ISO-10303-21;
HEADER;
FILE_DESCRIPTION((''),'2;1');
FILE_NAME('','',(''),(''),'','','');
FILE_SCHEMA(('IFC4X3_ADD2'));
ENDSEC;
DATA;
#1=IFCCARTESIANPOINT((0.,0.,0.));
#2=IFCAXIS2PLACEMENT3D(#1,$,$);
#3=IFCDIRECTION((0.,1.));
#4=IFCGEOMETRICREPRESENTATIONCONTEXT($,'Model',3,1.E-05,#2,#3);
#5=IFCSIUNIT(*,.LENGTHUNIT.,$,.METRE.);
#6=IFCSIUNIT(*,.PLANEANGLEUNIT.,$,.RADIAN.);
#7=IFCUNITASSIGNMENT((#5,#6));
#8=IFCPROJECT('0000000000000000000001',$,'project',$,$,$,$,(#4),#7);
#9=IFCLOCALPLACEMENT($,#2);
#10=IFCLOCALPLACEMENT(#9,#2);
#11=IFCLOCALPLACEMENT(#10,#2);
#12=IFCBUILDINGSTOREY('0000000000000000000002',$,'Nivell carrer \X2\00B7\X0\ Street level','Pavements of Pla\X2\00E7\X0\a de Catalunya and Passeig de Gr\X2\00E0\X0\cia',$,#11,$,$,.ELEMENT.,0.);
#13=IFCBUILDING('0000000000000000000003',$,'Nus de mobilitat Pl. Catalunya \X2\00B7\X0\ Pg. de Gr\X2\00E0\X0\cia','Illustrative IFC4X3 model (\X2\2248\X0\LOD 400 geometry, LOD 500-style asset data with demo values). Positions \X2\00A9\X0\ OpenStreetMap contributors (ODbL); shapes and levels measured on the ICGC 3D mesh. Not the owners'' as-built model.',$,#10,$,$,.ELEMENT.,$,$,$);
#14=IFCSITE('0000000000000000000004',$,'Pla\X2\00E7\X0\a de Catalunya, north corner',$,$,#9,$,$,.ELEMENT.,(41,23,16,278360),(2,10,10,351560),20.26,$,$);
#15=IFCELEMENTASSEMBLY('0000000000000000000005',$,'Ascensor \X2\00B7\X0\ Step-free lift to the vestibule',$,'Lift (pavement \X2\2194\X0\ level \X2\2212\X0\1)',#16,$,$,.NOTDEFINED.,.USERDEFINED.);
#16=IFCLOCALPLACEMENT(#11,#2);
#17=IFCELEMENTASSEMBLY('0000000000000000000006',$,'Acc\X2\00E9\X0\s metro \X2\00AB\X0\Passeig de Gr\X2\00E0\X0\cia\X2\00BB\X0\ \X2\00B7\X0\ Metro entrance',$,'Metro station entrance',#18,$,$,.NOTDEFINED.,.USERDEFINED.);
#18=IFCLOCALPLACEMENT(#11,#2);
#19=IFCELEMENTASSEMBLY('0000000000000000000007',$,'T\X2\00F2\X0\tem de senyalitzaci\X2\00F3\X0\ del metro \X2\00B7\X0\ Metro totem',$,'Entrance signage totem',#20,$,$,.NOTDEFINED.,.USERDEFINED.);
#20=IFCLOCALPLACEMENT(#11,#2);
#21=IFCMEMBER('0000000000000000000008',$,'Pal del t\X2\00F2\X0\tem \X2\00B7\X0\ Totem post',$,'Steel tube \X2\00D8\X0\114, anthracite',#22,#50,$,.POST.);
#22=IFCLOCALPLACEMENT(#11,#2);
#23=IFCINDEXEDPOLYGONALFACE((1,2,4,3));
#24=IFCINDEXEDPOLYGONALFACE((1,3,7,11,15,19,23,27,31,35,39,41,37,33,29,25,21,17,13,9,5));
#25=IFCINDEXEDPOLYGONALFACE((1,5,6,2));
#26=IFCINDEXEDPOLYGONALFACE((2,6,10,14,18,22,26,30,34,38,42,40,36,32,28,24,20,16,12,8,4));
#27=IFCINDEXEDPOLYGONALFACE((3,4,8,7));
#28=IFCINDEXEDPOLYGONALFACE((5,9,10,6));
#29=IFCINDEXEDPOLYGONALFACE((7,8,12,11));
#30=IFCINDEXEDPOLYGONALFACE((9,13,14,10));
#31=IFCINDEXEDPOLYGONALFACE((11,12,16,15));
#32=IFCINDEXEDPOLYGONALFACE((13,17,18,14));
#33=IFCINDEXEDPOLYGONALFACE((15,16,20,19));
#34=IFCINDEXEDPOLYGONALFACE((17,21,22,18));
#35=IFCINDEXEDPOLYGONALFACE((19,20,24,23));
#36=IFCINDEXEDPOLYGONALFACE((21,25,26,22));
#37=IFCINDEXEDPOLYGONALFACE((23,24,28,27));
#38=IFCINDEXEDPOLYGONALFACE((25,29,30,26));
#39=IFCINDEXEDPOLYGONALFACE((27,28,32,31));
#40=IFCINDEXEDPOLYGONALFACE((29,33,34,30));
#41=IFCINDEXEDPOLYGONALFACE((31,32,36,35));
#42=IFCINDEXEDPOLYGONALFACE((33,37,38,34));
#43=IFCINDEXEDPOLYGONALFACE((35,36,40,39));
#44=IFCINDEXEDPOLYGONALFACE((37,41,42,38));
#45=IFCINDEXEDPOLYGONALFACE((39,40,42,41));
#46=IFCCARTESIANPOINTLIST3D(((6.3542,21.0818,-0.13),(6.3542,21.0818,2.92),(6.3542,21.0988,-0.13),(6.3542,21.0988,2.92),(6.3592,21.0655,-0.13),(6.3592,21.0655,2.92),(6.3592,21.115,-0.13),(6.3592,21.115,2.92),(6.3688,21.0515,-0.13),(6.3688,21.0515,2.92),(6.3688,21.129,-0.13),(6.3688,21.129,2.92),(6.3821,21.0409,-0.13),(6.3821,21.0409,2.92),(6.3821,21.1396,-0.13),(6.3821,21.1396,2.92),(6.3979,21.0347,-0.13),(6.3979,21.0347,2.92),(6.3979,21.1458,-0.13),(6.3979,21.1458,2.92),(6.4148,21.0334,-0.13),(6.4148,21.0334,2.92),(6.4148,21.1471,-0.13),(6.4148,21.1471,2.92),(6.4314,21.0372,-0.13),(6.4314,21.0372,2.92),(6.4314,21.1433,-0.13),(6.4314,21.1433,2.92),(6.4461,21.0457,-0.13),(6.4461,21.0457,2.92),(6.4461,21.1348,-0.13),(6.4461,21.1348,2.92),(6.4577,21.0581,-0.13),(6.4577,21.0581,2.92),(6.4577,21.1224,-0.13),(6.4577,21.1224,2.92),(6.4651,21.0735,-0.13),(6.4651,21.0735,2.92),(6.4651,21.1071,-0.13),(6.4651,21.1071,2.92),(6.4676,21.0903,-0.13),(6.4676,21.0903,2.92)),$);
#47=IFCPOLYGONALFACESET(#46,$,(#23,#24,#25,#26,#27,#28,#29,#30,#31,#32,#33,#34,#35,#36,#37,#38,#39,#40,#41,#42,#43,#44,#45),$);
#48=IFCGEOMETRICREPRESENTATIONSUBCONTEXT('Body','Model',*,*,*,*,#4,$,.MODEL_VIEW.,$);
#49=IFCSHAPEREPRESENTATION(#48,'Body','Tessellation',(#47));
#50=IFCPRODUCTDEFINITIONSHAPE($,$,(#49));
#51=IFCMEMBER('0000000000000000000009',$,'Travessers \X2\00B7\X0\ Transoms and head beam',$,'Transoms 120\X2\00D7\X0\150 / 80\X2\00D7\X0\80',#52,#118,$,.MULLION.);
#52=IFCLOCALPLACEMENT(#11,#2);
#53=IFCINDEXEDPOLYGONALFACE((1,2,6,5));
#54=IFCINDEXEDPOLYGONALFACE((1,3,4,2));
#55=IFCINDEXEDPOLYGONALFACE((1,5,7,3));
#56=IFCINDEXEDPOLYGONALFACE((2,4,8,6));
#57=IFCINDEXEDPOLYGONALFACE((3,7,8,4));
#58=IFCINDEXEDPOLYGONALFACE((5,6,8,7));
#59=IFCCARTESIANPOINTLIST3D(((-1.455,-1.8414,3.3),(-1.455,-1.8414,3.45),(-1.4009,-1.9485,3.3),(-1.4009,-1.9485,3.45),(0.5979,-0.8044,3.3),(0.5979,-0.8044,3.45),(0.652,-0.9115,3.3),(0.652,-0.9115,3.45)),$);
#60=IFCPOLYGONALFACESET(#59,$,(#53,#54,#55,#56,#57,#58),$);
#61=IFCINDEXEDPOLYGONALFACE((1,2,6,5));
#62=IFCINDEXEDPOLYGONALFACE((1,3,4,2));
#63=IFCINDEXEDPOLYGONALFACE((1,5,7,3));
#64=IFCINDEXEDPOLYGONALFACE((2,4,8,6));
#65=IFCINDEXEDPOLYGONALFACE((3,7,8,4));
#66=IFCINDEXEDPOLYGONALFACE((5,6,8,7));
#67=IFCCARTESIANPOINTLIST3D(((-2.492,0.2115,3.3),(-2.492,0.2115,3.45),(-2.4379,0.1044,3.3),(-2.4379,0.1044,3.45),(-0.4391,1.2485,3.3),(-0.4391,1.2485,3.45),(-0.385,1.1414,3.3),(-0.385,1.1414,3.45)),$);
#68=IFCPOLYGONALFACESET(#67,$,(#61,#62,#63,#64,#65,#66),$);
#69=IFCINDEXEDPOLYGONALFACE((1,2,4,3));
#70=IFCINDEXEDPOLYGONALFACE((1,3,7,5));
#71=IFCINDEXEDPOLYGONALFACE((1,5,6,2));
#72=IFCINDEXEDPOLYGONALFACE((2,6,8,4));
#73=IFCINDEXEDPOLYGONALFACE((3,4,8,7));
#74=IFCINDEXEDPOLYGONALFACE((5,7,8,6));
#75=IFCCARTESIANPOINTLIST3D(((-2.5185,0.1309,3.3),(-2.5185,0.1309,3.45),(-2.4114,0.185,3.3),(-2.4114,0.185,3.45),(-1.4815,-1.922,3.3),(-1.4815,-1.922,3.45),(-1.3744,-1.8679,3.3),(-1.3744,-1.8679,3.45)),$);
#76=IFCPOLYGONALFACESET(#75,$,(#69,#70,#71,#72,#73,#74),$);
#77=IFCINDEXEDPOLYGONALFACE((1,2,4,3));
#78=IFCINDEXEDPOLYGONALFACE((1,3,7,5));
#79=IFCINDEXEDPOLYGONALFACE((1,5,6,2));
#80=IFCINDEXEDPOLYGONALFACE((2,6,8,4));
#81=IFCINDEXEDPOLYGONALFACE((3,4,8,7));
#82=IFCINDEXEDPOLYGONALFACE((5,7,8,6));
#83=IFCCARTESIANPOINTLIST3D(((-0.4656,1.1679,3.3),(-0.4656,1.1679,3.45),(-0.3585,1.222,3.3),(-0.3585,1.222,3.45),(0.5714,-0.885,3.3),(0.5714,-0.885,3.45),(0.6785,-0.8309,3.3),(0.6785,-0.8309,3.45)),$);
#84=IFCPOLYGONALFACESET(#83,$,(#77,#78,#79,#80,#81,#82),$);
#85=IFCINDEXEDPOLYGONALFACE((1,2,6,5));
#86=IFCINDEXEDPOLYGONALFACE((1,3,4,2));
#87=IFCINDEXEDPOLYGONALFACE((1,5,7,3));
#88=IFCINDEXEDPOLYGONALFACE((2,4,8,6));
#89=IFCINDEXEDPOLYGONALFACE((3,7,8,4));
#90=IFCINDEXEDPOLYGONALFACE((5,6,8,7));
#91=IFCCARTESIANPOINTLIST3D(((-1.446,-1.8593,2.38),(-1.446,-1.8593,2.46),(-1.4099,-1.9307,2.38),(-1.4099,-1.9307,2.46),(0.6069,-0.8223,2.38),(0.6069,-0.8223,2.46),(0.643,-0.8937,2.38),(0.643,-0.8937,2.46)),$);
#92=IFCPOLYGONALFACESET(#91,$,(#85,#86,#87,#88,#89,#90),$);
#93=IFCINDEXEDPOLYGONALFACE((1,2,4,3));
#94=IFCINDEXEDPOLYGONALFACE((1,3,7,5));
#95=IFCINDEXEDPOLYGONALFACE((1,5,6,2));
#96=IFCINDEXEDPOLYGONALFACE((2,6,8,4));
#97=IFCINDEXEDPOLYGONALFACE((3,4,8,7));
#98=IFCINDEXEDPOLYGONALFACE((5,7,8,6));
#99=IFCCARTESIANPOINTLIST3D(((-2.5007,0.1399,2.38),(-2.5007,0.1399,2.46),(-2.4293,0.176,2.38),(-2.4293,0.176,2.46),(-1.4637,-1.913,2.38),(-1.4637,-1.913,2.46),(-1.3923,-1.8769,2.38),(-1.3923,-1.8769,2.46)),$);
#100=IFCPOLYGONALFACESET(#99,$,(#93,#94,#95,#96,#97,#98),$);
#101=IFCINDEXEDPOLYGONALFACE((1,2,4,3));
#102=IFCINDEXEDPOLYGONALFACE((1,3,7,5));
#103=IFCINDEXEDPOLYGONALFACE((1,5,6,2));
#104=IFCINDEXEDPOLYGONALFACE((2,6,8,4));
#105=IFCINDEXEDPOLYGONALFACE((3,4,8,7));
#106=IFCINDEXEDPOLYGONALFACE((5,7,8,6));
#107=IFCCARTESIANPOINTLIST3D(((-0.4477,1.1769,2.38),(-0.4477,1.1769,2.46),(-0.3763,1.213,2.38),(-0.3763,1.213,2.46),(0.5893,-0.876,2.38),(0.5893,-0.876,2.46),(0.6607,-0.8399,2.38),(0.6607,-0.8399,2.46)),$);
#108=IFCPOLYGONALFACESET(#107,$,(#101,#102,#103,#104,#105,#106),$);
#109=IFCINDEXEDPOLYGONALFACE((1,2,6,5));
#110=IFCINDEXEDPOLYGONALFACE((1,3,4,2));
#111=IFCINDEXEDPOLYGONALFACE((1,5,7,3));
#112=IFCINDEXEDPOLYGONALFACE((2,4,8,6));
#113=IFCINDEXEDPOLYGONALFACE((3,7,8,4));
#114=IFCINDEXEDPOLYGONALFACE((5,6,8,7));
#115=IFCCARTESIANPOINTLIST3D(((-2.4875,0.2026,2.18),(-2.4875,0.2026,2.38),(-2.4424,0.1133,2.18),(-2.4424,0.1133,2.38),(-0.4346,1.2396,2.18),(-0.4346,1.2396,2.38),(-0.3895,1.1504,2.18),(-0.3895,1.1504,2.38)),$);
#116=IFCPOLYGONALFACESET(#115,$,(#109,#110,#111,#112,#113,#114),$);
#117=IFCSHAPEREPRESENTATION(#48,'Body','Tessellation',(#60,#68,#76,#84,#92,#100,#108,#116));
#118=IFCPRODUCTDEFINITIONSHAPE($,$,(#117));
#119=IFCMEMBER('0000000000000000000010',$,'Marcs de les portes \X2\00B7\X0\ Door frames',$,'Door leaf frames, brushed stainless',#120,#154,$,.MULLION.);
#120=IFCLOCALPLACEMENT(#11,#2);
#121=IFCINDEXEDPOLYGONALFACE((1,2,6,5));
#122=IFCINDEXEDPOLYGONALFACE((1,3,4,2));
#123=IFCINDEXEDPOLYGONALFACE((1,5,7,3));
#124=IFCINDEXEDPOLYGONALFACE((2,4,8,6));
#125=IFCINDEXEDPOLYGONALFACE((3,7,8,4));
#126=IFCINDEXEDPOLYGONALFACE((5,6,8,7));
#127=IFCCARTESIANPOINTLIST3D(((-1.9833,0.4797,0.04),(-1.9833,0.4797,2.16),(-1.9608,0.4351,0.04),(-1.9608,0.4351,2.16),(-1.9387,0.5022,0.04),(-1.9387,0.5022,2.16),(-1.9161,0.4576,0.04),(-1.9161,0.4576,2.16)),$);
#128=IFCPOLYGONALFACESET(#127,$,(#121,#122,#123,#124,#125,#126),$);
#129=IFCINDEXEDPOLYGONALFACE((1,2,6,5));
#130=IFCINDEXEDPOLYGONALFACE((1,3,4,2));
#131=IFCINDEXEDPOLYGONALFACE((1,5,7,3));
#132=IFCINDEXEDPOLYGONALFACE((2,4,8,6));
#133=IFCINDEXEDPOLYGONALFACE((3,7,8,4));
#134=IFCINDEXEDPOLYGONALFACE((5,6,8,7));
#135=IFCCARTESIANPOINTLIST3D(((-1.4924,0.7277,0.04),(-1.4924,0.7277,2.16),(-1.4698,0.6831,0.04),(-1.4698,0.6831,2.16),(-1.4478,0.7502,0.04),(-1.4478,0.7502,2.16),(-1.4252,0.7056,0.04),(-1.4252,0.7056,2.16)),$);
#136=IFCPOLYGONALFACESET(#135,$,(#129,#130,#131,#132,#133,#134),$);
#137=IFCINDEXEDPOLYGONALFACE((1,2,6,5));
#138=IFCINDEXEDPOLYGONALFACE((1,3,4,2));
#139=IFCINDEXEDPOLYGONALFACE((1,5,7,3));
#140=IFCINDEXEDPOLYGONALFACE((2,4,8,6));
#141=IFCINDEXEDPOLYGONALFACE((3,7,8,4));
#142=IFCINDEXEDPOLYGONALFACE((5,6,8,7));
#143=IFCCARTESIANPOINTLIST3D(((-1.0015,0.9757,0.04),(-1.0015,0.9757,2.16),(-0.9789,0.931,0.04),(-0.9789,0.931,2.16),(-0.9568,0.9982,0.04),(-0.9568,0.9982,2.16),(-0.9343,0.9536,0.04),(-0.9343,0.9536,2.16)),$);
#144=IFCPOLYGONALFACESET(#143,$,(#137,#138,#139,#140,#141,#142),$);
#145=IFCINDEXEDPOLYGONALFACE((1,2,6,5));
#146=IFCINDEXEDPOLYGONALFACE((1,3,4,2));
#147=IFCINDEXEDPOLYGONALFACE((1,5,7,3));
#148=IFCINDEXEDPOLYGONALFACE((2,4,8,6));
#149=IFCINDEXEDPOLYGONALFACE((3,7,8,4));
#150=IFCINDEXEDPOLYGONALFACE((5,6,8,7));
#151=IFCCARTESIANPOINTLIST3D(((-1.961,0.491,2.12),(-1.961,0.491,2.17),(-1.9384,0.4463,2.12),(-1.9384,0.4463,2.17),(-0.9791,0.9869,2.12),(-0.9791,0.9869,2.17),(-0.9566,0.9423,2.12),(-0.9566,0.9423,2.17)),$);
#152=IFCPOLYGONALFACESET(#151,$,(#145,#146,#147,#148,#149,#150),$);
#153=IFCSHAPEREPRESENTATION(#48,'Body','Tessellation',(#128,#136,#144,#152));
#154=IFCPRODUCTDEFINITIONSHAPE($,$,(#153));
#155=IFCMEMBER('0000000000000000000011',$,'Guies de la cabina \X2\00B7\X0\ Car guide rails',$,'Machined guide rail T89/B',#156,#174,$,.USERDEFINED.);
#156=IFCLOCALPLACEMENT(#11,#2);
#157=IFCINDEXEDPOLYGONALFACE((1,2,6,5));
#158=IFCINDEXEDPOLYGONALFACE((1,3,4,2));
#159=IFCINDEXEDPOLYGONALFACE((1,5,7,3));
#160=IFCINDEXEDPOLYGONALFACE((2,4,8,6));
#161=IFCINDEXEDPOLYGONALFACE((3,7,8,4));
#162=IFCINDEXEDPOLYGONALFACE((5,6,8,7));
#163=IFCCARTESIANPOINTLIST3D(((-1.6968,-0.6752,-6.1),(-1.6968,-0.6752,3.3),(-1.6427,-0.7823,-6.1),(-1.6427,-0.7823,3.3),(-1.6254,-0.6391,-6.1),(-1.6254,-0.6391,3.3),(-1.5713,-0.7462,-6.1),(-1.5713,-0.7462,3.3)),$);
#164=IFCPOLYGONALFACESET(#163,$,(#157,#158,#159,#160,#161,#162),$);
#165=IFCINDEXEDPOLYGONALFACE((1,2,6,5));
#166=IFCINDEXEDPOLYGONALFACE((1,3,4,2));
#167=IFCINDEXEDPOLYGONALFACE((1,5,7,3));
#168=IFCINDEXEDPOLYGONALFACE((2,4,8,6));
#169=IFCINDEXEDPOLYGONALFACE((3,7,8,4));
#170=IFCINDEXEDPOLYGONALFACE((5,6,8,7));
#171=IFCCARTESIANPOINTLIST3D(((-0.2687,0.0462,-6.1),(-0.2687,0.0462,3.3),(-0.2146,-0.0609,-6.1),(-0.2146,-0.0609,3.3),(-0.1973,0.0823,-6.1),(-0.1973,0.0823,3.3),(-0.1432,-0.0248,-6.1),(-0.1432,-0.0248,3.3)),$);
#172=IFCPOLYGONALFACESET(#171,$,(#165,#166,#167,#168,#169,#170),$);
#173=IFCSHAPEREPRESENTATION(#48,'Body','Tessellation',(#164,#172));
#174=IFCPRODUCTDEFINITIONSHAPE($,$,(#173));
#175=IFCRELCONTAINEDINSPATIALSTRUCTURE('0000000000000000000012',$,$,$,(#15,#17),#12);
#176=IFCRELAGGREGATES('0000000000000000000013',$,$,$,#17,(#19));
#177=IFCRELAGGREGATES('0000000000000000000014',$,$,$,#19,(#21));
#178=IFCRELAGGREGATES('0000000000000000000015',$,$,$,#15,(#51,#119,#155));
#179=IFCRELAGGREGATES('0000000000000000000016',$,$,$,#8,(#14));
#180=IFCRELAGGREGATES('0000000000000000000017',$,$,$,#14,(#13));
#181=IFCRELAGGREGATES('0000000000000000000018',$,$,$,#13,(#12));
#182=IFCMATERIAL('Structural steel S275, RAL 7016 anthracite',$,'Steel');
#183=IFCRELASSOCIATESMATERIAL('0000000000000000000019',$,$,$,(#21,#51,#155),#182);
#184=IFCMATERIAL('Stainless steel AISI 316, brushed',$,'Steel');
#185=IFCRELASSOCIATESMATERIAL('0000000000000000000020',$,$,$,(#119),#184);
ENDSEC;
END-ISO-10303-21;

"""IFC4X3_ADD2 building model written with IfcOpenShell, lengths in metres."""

from ifc_helpers import new_model, si_unit, direction, frame, frame_2d, origin, origin_2d_with_axis, place, context, subcontext, project, spatial, rectangle, circle, extrude, material, element, aggregate, save


model = new_model("IFC4X3_ADD2")

# Units and contexts
model_context = context("Model", 3, precision=1e-05, world=origin(), true_north=direction((0.0, 1.0)))
body_context = subcontext(model_context, "Body", "Model", "MODEL_VIEW")
ifc_project = project(units=[si_unit("LENGTHUNIT", "METRE"), si_unit("PLANEANGLEUNIT", "RADIAN")], contexts=[model_context])

# Site, building, storey
site_placement = place(None, origin())
site = spatial("IfcSite", under=ifc_project, at=site_placement, Name="Plaça de Catalunya, north corner", CompositionType="ELEMENT", RefLatitude=(41, 23, 16, 278360), RefLongitude=(2, 10, 10, 351560), RefElevation=20.26)
building_placement = place(site_placement, origin())
building = spatial("IfcBuilding", under=site, at=building_placement, Name="Nus de mobilitat Pl. Catalunya · Pg. de Gràcia", Description="Illustrative IFC4X3 model (≈LOD 400 geometry, LOD 500-style asset data with demo values). Positions © OpenStreetMap contributors (ODbL); shapes and levels measured on the ICGC 3D mesh. Not the owners' as-built model.", CompositionType="ELEMENT")
storey_placement = place(building_placement, origin())
storey = spatial("IfcBuildingStorey", under=building, at=storey_placement, Name="Nivell carrer · Street level", Description="Pavements of Plaça de Catalunya and Passeig de Gràcia", CompositionType="ELEMENT", Elevation=0.0)

# Element assembly
assembly_1_placement = place(building_placement, origin())
assembly_1 = element("IfcElementAssembly", 1, at=assembly_1_placement, inside=storey, Name="Ascensor · Step-free lift to the vestibule", ObjectType="Lift (pavement ↔ level −1)", AssemblyPlace="NOTDEFINED", PredefinedType="USERDEFINED")
ifc_material_1 = material(Name="Structural steel S275, RAL 7016 anthracite", Category="Steel")

# Element assemblies, member
assembly_2_placement = place(building_placement, origin())
assembly_2 = element("IfcElementAssembly", 2, at=assembly_2_placement, inside=storey, Name="Accés metro «Passeig de Gràcia» · Metro entrance", ObjectType="Metro station entrance", AssemblyPlace="NOTDEFINED", PredefinedType="USERDEFINED")
ifc_material_2 = material(Name="Stainless steel AISI 316, brushed", Category="Steel")
assembly_3_placement = place(building_placement, origin())
assembly_3 = element("IfcElementAssembly", 3, at=assembly_3_placement, Name="Tòtem de senyalització del metro · Metro totem", ObjectType="Entrance signage totem", AssemblyPlace="NOTDEFINED", PredefinedType="USERDEFINED")
member_1_placement = place(building_placement, origin())
member_1 = element("IfcMember", 4, at=member_1_placement, material=ifc_material_1, Name="Pal del tòtem · Totem post", ObjectType="Steel tube Ø114, anthracite", PredefinedType="POST", context=body_context, shape_type="SweptSolid", body=[
    extrude(circle(Radius=0.057, at=origin_2d_with_axis()), frame((6.4106, 21.0903, -0.13)), (0.0, 0.0, 1.0), 3.05),
])

# Members
member_2_placement = place(building_placement, origin())
member_2 = element("IfcMember", 5, at=member_2_placement, material=ifc_material_1, Name="Travessers · Transoms and head beam", ObjectType="Transoms 120×150 / 80×80", PredefinedType="MULLION", context=body_context, shape_type="SweptSolid", body=[
    extrude(rectangle(XDim=2.3, YDim=0.12, at=frame_2d((0.0, 0.0), x_axis=(0.892586, 0.450878))), frame((-0.4015, -1.3765, 3.3)), (0.0, 0.0, 1.0), 0.15),
    extrude(rectangle(XDim=2.3, YDim=0.12, at=frame_2d((0.0, 0.0), x_axis=(0.892586, 0.450878))), frame((-1.4385, 0.6765, 3.3)), (0.0, 0.0, 1.0), 0.15),
    extrude(rectangle(XDim=0.12, YDim=2.3, at=frame_2d((0.0, 0.0), x_axis=(0.892586, 0.450878))), frame((-1.9465, -0.8685, 3.3)), (0.0, 0.0, 1.0), 0.15),
    extrude(rectangle(XDim=0.12, YDim=2.3, at=frame_2d((0.0, 0.0), x_axis=(0.892586, 0.450878))), frame((0.1065, 0.1685, 3.3)), (0.0, 0.0, 1.0), 0.15),
    extrude(rectangle(XDim=2.3, YDim=0.08, at=frame_2d((0.0, 0.0), x_axis=(0.892586, 0.450878))), frame((-0.4015, -1.3765, 2.38)), (0.0, 0.0, 1.0), 0.08),
    extrude(rectangle(XDim=0.08, YDim=2.3, at=frame_2d((0.0, 0.0), x_axis=(0.892586, 0.450878))), frame((-1.9465, -0.8685, 2.38)), (0.0, 0.0, 1.0), 0.08),
    extrude(rectangle(XDim=0.08, YDim=2.3, at=frame_2d((0.0, 0.0), x_axis=(0.892586, 0.450878))), frame((0.1065, 0.1685, 2.38)), (0.0, 0.0, 1.0), 0.08),
    extrude(rectangle(XDim=2.3, YDim=0.1, at=frame_2d((0.0, 0.0), x_axis=(0.892586, 0.450878))), frame((-1.4385, 0.6765, 2.18)), (0.0, 0.0, 1.0), 0.2),
])
member_3_placement = place(building_placement, origin())
member_3 = element("IfcMember", 6, at=member_3_placement, material=ifc_material_2, Name="Marcs de les portes · Door frames", ObjectType="Door leaf frames, brushed stainless", PredefinedType="MULLION", context=body_context, shape_type="SweptSolid", body=[
    extrude(rectangle(XDim=0.05, YDim=0.05, at=frame_2d((0.0, 0.0), x_axis=(0.892586, 0.450878))), frame((-1.9497, 0.4687, 0.04)), (0.0, 0.0, 1.0), 2.12),
    extrude(rectangle(XDim=0.05, YDim=0.05, at=frame_2d((0.0, 0.0), x_axis=(0.892586, 0.450878))), frame((-1.4588, 0.7166, 0.04)), (0.0, 0.0, 1.0), 2.12),
    extrude(rectangle(XDim=0.05, YDim=0.05, at=frame_2d((0.0, 0.0), x_axis=(0.892586, 0.450878))), frame((-0.9679, 0.9646, 0.04)), (0.0, 0.0, 1.0), 2.12),
    extrude(rectangle(XDim=1.1, YDim=0.05, at=frame_2d((0.0, 0.0), x_axis=(0.892586, 0.450878))), frame((-1.4588, 0.7166, 2.12)), (0.0, 0.0, 1.0), 0.05),
])
member_4_placement = place(building_placement, origin())
member_4 = element("IfcMember", 7, at=member_4_placement, material=ifc_material_1, Name="Guies de la cabina · Car guide rails", ObjectType="Machined guide rail T89/B", PredefinedType="USERDEFINED", context=body_context, shape_type="SweptSolid", body=[
    extrude(rectangle(XDim=0.08, YDim=0.12, at=frame_2d((0.0, 0.0), x_axis=(0.892586, 0.450878))), frame((-1.6341, -0.7107, -6.1)), (0.0, 0.0, 1.0), 9.4),
    extrude(rectangle(XDim=0.08, YDim=0.12, at=frame_2d((0.0, 0.0), x_axis=(0.892586, 0.450878))), frame((-0.2059, 0.0107, -6.1)), (0.0, 0.0, 1.0), 9.4),
])

aggregate(assembly_2, [assembly_3])

aggregate(assembly_3, [member_1])
aggregate(assembly_1, [member_2, member_3, member_4])

save(model, "model.ifc")
